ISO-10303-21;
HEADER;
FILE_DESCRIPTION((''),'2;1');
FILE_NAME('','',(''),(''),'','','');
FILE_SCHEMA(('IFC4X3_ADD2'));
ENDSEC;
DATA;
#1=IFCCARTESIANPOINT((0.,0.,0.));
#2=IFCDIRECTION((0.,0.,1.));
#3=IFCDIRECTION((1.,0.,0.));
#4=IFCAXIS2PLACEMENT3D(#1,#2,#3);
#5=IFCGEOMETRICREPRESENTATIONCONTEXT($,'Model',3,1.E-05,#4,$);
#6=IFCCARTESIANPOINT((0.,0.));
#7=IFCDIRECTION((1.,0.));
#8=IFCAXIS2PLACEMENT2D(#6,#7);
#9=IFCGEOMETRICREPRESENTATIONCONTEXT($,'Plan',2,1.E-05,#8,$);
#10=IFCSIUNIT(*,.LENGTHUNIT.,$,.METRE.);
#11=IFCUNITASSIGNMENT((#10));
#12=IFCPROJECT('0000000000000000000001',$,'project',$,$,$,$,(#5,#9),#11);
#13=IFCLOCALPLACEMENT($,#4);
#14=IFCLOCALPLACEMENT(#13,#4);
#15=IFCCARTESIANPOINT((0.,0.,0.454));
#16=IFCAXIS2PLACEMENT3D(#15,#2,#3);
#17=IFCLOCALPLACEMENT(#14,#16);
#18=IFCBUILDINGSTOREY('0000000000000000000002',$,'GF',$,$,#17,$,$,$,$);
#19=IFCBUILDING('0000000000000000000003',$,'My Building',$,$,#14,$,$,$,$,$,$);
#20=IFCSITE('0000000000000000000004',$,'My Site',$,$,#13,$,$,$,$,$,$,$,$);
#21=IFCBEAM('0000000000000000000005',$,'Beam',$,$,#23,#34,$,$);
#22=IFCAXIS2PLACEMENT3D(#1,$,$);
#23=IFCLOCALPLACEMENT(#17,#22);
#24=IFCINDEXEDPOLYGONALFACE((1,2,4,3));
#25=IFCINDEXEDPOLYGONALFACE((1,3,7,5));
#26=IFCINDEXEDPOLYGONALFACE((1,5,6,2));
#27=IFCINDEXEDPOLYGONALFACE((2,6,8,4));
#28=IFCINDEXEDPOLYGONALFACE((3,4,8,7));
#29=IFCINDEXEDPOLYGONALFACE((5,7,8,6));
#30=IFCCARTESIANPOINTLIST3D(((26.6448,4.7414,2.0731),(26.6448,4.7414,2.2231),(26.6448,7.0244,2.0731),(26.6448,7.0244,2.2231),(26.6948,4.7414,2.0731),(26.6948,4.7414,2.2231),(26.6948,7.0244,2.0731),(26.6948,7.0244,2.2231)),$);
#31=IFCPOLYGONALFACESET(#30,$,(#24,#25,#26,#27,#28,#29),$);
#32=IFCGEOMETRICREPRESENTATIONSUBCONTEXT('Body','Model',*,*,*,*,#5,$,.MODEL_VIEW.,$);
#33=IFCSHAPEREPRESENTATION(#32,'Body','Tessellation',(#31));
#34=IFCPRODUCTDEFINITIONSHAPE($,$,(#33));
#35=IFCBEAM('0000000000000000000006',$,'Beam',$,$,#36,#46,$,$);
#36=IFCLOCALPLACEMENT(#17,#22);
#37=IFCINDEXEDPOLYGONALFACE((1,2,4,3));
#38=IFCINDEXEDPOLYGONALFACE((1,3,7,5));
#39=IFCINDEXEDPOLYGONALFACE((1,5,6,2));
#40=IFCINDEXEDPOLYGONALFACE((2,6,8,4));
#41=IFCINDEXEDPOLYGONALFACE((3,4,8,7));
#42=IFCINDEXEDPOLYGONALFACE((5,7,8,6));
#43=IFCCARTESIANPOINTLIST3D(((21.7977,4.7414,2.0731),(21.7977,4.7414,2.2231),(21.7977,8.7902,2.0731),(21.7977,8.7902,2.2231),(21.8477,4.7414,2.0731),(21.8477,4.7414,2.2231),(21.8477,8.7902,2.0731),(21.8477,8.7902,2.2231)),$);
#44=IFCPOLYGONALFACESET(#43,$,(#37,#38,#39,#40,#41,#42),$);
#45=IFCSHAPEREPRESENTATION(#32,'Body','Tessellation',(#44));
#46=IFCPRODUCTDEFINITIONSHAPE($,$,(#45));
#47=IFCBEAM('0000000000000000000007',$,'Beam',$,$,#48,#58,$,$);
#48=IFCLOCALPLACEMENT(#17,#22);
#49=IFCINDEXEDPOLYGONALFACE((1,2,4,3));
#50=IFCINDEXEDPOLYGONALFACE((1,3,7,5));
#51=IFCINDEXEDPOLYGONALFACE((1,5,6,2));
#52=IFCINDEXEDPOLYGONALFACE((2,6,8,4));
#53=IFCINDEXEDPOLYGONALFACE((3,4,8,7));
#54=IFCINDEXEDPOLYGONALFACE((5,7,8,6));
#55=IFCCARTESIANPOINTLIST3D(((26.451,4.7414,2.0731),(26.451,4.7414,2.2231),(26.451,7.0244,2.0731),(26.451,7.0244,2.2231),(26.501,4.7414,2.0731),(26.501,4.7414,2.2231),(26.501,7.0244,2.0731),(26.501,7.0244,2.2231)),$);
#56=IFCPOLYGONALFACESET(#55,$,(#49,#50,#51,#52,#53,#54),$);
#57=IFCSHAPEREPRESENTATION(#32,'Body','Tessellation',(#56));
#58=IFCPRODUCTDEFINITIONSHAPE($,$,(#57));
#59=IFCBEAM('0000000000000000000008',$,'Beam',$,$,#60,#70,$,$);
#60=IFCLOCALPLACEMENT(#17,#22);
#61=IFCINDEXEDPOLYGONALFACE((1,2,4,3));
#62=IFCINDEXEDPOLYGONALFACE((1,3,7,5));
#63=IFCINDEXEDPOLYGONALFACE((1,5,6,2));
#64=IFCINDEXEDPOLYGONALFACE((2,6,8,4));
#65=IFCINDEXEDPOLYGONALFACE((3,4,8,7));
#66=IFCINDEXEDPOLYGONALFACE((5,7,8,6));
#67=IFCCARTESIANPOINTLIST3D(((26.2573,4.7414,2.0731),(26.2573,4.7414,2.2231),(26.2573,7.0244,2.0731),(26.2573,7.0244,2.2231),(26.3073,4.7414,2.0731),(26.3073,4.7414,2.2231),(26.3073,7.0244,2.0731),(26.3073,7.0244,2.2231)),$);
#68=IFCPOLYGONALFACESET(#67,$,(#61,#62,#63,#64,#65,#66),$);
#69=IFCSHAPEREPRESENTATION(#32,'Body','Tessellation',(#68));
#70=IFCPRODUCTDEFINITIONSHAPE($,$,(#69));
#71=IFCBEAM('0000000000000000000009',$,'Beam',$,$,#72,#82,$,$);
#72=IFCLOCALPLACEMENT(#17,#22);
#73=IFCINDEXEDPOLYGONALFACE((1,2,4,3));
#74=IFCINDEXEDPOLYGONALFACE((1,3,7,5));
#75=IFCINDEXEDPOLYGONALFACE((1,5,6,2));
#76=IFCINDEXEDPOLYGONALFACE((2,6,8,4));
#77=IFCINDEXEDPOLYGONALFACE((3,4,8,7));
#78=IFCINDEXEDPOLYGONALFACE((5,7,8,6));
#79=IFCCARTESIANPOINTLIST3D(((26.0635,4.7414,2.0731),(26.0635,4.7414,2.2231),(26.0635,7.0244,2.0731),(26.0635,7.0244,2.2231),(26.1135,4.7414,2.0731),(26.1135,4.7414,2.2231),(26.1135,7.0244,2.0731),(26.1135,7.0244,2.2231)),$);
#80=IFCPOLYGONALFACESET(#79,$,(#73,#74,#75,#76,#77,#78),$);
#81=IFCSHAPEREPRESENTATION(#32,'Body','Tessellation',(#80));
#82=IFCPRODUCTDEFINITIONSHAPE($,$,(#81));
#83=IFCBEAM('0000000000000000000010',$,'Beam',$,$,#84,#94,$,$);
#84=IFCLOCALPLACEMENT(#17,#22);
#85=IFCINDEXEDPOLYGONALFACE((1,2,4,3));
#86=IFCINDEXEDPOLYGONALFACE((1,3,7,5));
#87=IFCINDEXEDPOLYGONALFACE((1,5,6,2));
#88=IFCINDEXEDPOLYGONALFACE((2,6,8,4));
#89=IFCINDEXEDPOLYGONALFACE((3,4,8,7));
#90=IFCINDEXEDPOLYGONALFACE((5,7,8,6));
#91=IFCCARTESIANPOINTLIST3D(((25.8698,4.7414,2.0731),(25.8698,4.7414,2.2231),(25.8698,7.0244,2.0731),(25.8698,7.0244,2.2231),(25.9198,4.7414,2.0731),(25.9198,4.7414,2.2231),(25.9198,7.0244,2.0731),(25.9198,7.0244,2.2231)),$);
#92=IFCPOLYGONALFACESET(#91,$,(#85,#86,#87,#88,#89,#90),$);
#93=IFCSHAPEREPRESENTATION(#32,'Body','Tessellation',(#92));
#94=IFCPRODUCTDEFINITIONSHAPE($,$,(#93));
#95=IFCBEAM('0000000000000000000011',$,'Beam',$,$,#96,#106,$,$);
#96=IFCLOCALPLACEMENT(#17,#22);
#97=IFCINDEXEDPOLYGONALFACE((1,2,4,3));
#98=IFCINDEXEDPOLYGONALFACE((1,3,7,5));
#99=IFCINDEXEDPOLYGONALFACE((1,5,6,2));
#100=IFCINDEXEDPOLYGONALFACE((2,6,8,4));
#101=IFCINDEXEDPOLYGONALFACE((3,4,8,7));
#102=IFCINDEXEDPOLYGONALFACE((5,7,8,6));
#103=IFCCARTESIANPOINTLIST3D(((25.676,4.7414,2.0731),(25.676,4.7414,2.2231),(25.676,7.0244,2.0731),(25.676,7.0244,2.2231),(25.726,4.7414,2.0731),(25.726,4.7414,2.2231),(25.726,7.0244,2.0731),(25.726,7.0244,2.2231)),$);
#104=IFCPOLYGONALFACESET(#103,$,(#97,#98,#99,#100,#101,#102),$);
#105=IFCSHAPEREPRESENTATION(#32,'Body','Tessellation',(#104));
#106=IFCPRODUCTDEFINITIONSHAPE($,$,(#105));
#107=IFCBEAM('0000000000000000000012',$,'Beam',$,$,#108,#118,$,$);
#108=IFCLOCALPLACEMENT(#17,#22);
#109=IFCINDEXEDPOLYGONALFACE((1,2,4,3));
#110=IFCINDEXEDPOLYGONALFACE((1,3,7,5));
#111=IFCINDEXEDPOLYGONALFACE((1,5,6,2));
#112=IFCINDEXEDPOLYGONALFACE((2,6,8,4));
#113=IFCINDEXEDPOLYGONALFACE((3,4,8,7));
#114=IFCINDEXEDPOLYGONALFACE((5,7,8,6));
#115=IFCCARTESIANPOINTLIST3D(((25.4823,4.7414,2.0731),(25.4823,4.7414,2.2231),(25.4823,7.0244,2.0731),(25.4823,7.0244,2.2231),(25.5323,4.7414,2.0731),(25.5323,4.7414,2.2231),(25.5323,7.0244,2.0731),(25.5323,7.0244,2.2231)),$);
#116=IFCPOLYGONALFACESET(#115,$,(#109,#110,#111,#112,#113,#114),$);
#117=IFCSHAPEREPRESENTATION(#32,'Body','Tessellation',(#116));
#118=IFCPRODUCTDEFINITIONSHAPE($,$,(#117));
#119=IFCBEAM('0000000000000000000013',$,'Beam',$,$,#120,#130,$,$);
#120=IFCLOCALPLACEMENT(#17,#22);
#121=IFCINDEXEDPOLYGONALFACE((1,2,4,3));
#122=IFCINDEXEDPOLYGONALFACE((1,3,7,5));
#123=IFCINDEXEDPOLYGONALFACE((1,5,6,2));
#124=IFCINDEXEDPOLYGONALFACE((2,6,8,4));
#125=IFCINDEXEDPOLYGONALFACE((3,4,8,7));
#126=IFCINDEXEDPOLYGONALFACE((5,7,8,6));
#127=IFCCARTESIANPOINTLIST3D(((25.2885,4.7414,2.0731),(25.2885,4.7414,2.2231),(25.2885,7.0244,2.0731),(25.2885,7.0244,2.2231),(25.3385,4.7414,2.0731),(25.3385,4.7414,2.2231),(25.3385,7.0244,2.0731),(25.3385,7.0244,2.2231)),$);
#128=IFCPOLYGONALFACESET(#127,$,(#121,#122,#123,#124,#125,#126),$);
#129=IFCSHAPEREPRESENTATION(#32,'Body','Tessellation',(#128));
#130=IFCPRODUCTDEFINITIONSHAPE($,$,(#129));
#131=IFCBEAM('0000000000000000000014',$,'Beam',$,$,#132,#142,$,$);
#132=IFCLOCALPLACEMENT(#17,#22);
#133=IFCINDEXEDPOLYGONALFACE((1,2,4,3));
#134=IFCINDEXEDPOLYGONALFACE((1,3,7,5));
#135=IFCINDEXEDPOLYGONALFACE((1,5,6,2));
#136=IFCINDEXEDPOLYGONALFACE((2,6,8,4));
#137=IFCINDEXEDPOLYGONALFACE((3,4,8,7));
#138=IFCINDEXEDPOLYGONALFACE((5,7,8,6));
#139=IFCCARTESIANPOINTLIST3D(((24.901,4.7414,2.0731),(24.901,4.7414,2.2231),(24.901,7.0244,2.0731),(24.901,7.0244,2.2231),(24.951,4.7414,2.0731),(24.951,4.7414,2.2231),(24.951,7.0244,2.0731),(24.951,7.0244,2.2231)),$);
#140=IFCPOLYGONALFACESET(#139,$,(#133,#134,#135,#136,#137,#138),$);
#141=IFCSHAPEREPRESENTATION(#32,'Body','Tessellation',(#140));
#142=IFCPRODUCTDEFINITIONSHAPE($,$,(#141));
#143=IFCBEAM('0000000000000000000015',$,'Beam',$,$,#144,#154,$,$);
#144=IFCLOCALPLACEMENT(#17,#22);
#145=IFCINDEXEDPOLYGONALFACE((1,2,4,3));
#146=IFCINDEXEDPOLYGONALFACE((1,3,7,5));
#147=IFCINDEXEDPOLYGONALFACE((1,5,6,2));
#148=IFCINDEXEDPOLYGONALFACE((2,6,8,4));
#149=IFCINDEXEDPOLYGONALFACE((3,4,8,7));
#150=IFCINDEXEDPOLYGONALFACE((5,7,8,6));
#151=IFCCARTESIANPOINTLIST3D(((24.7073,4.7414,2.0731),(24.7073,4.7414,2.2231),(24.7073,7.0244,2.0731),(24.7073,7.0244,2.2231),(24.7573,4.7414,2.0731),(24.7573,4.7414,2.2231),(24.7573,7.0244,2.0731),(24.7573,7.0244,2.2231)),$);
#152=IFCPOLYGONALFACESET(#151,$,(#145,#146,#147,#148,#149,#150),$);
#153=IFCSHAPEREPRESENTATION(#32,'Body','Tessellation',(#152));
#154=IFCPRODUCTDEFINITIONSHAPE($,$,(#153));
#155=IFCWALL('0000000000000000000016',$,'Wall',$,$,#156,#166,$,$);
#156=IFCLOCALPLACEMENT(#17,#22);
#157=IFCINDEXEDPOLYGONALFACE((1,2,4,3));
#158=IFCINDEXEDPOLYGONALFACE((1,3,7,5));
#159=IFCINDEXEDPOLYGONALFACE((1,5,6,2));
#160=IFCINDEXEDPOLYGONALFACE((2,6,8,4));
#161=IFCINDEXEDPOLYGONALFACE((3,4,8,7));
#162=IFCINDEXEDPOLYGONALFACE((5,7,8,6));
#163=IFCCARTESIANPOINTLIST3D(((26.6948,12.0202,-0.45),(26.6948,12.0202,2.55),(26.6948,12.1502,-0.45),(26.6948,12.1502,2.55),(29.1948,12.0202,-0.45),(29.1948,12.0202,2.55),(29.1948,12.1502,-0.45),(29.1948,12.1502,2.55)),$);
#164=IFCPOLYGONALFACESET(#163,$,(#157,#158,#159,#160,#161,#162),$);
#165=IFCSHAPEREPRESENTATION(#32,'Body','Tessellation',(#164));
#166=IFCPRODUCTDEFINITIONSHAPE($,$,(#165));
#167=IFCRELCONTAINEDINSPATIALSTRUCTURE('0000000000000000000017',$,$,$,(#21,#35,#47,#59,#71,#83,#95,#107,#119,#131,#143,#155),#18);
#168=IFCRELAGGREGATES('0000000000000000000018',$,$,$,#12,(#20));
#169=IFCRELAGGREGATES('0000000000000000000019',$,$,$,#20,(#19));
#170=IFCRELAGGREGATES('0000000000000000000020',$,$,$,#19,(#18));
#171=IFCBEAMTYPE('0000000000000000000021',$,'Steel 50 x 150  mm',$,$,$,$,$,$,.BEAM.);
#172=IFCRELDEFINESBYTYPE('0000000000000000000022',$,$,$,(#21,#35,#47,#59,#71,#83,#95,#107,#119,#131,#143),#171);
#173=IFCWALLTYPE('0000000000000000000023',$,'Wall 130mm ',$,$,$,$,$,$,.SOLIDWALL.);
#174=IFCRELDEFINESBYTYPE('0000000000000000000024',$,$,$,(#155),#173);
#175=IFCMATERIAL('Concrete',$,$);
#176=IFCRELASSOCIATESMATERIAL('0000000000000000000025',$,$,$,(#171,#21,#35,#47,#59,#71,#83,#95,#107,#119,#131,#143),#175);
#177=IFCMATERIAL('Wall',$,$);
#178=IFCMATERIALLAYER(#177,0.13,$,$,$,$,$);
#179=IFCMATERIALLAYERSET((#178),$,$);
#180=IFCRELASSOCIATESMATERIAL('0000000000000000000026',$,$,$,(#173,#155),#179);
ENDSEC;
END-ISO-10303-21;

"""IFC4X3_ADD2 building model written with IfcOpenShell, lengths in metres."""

from ifc_helpers import new_model, si_unit, frame, origin_with_axes, origin_2d_with_axis, place, context, subcontext, project, spatial, indexed_curve, rectangle, outline, extrude, material, layer, layer_set, layer_usage, material_profile, profile_set, profile_usage, type_object, element, save


model = new_model("IFC4X3_ADD2")

# Units and contexts
model_context = context("Model", 3, precision=1e-05, world=origin_with_axes())
plan_context = context("Plan", 2, precision=1e-05, world=origin_2d_with_axis())
body_context_1 = subcontext(model_context, "Body", "Model", "MODEL_VIEW")
ifc_project = project(units=[si_unit("LENGTHUNIT", "METRE")], contexts=[model_context, plan_context])

# Site, building, storey
site_placement = place(None, origin_with_axes())
site = spatial("IfcSite", under=ifc_project, at=site_placement, Name="My Site")
building_placement = place(site_placement, origin_with_axes())
building = spatial("IfcBuilding", under=site, at=building_placement, Name="My Building")
storey_placement = place(building_placement, frame((0.0, 0.0, 0.454), z_axis=(0.0, 0.0, 1.0), x_axis=(1.0, 0.0, 0.0)))
storey = spatial("IfcBuildingStorey", under=building, at=storey_placement, Name="GF")

# Beams
ifc_material_1 = material(Name="Concrete")
ifc_material_profile = material_profile(ifc_material_1, rectangle(XDim=0.05, YDim=0.15))
ifc_profile_set = profile_set([ifc_material_profile])
ifc_profile_usage_1 = profile_usage(ifc_profile_set)
beam_type = type_object("IfcBeamType", Name="Steel 50 x 150  mm", PredefinedType="BEAM", material=ifc_profile_set)
beam_1_placement = place(storey_placement, frame((26.6698, 7.0244, 2.1481), z_axis=(0.0, -1.0, 0.0), x_axis=(1.0, 0.0, 0.0)))
element("IfcBeam", 1, at=beam_1_placement, inside=storey, type_object=beam_type, material=ifc_profile_usage_1, Name="Beam", context=body_context_1, shape_type="SweptSolid", body=[
    extrude(rectangle(XDim=0.05, YDim=0.15), origin_with_axes(), (0.0, 0.0, 1.0), 2.283),
])
ifc_profile_usage_2 = profile_usage(ifc_profile_set)
beam_2_placement = place(storey_placement, frame((21.8227, 8.7902, 2.1481), z_axis=(0.0, -1.0, 0.0), x_axis=(1.0, 0.0, 0.0)))
element("IfcBeam", 2, at=beam_2_placement, inside=storey, type_object=beam_type, material=ifc_profile_usage_2, Name="Beam", context=body_context_1, shape_type="SweptSolid", body=[
    extrude(rectangle(XDim=0.05, YDim=0.15), origin_with_axes(), (0.0, 0.0, 1.0), 4.0488),
])
ifc_profile_usage_3 = profile_usage(ifc_profile_set)
beam_3_placement = place(storey_placement, frame((26.476, 7.0244, 2.1481), z_axis=(0.0, -1.0, 0.0), x_axis=(1.0, 0.0, 0.0)))
element("IfcBeam", 3, at=beam_3_placement, inside=storey, type_object=beam_type, material=ifc_profile_usage_3, Name="Beam", context=body_context_1, shape_type="SweptSolid", body=[
    extrude(rectangle(XDim=0.05, YDim=0.15), origin_with_axes(), (0.0, 0.0, 1.0), 2.283),
])
ifc_profile_usage_4 = profile_usage(ifc_profile_set)
beam_4_placement = place(storey_placement, frame((26.2823, 7.0244, 2.1481), z_axis=(0.0, -1.0, 0.0), x_axis=(1.0, 0.0, 0.0)))
element("IfcBeam", 4, at=beam_4_placement, inside=storey, type_object=beam_type, material=ifc_profile_usage_4, Name="Beam", context=body_context_1, shape_type="SweptSolid", body=[
    extrude(rectangle(XDim=0.05, YDim=0.15), origin_with_axes(), (0.0, 0.0, 1.0), 2.283),
])
ifc_profile_usage_5 = profile_usage(ifc_profile_set)
beam_5_placement = place(storey_placement, frame((26.0885, 7.0244, 2.1481), z_axis=(0.0, -1.0, 0.0), x_axis=(1.0, 0.0, 0.0)))
element("IfcBeam", 5, at=beam_5_placement, inside=storey, type_object=beam_type, material=ifc_profile_usage_5, Name="Beam", context=body_context_1, shape_type="SweptSolid", body=[
    extrude(rectangle(XDim=0.05, YDim=0.15), origin_with_axes(), (0.0, 0.0, 1.0), 2.283),
])
ifc_profile_usage_6 = profile_usage(ifc_profile_set)
beam_6_placement = place(storey_placement, frame((25.8948, 7.0244, 2.1481), z_axis=(0.0, -1.0, 0.0), x_axis=(1.0, 0.0, 0.0)))
element("IfcBeam", 6, at=beam_6_placement, inside=storey, type_object=beam_type, material=ifc_profile_usage_6, Name="Beam", context=body_context_1, shape_type="SweptSolid", body=[
    extrude(rectangle(XDim=0.05, YDim=0.15), origin_with_axes(), (0.0, 0.0, 1.0), 2.283),
])
ifc_profile_usage_7 = profile_usage(ifc_profile_set)
beam_7_placement = place(storey_placement, frame((25.701, 7.0244, 2.1481), z_axis=(0.0, -1.0, 0.0), x_axis=(1.0, 0.0, 0.0)))
element("IfcBeam", 7, at=beam_7_placement, inside=storey, type_object=beam_type, material=ifc_profile_usage_7, Name="Beam", context=body_context_1, shape_type="SweptSolid", body=[
    extrude(rectangle(XDim=0.05, YDim=0.15), origin_with_axes(), (0.0, 0.0, 1.0), 2.283),
])
ifc_profile_usage_8 = profile_usage(ifc_profile_set)
beam_8_placement = place(storey_placement, frame((25.5073, 7.0244, 2.1481), z_axis=(0.0, -1.0, 0.0), x_axis=(1.0, 0.0, 0.0)))
element("IfcBeam", 8, at=beam_8_placement, inside=storey, type_object=beam_type, material=ifc_profile_usage_8, Name="Beam", context=body_context_1, shape_type="SweptSolid", body=[
    extrude(rectangle(XDim=0.05, YDim=0.15), origin_with_axes(), (0.0, 0.0, 1.0), 2.283),
])
ifc_profile_usage_9 = profile_usage(ifc_profile_set)
beam_9_placement = place(storey_placement, frame((25.3135, 7.0244, 2.1481), z_axis=(0.0, -1.0, 0.0), x_axis=(1.0, 0.0, 0.0)))
element("IfcBeam", 9, at=beam_9_placement, inside=storey, type_object=beam_type, material=ifc_profile_usage_9, Name="Beam", context=body_context_1, shape_type="SweptSolid", body=[
    extrude(rectangle(XDim=0.05, YDim=0.15), origin_with_axes(), (0.0, 0.0, 1.0), 2.283),
])
ifc_profile_usage_10 = profile_usage(ifc_profile_set)
beam_10_placement = place(storey_placement, frame((24.926, 7.0244, 2.1481), z_axis=(0.0, -1.0, 0.0), x_axis=(1.0, 0.0, 0.0)))
element("IfcBeam", 10, at=beam_10_placement, inside=storey, type_object=beam_type, material=ifc_profile_usage_10, Name="Beam", context=body_context_1, shape_type="SweptSolid", body=[
    extrude(rectangle(XDim=0.05, YDim=0.15), origin_with_axes(), (0.0, 0.0, 1.0), 2.283),
])
ifc_profile_usage_11 = profile_usage(ifc_profile_set)
beam_11_placement = place(storey_placement, frame((24.7323, 7.0244, 2.1481), z_axis=(0.0, -1.0, 0.0), x_axis=(1.0, 0.0, 0.0)))
element("IfcBeam", 11, at=beam_11_placement, inside=storey, type_object=beam_type, material=ifc_profile_usage_11, Name="Beam", context=body_context_1, shape_type="SweptSolid", body=[
    extrude(rectangle(XDim=0.05, YDim=0.15), origin_with_axes(), (0.0, 0.0, 1.0), 2.283),
])

# Wall
ifc_material_2 = material(Name="Wall")
ifc_layer_1 = layer(ifc_material_2, 0.13)
ifc_layer_set_1 = layer_set([ifc_layer_1])
ifc_layer_usage_1 = layer_usage(ifc_layer_set_1, "AXIS2", "POSITIVE", 0.0)
wall_type_1 = type_object("IfcWallType", Name="Wall 130mm ", PredefinedType="SOLIDWALL", material=ifc_layer_set_1)
wall_1_placement = place(storey_placement, frame((29.1948, 12.1502, -0.45), z_axis=(0.0, 0.0, 1.0), x_axis=(-1.0, 0.0, 0.0)))
element("IfcWall", 12, at=wall_1_placement, inside=storey, type_object=wall_type_1, material=ifc_layer_usage_1, Name="Wall", context=body_context_1, shape_type="SweptSolid", body=[
    extrude(outline(indexed_curve([(0.0, 0.0), (0.0, 0.13), (2.5, 0.13), (2.5, 0.0), (0.0, 0.0)], self_intersect=False)), origin_with_axes(), (0.0, 0.0, 1.0), 3.0),
])

save(model, "model.ifc")
